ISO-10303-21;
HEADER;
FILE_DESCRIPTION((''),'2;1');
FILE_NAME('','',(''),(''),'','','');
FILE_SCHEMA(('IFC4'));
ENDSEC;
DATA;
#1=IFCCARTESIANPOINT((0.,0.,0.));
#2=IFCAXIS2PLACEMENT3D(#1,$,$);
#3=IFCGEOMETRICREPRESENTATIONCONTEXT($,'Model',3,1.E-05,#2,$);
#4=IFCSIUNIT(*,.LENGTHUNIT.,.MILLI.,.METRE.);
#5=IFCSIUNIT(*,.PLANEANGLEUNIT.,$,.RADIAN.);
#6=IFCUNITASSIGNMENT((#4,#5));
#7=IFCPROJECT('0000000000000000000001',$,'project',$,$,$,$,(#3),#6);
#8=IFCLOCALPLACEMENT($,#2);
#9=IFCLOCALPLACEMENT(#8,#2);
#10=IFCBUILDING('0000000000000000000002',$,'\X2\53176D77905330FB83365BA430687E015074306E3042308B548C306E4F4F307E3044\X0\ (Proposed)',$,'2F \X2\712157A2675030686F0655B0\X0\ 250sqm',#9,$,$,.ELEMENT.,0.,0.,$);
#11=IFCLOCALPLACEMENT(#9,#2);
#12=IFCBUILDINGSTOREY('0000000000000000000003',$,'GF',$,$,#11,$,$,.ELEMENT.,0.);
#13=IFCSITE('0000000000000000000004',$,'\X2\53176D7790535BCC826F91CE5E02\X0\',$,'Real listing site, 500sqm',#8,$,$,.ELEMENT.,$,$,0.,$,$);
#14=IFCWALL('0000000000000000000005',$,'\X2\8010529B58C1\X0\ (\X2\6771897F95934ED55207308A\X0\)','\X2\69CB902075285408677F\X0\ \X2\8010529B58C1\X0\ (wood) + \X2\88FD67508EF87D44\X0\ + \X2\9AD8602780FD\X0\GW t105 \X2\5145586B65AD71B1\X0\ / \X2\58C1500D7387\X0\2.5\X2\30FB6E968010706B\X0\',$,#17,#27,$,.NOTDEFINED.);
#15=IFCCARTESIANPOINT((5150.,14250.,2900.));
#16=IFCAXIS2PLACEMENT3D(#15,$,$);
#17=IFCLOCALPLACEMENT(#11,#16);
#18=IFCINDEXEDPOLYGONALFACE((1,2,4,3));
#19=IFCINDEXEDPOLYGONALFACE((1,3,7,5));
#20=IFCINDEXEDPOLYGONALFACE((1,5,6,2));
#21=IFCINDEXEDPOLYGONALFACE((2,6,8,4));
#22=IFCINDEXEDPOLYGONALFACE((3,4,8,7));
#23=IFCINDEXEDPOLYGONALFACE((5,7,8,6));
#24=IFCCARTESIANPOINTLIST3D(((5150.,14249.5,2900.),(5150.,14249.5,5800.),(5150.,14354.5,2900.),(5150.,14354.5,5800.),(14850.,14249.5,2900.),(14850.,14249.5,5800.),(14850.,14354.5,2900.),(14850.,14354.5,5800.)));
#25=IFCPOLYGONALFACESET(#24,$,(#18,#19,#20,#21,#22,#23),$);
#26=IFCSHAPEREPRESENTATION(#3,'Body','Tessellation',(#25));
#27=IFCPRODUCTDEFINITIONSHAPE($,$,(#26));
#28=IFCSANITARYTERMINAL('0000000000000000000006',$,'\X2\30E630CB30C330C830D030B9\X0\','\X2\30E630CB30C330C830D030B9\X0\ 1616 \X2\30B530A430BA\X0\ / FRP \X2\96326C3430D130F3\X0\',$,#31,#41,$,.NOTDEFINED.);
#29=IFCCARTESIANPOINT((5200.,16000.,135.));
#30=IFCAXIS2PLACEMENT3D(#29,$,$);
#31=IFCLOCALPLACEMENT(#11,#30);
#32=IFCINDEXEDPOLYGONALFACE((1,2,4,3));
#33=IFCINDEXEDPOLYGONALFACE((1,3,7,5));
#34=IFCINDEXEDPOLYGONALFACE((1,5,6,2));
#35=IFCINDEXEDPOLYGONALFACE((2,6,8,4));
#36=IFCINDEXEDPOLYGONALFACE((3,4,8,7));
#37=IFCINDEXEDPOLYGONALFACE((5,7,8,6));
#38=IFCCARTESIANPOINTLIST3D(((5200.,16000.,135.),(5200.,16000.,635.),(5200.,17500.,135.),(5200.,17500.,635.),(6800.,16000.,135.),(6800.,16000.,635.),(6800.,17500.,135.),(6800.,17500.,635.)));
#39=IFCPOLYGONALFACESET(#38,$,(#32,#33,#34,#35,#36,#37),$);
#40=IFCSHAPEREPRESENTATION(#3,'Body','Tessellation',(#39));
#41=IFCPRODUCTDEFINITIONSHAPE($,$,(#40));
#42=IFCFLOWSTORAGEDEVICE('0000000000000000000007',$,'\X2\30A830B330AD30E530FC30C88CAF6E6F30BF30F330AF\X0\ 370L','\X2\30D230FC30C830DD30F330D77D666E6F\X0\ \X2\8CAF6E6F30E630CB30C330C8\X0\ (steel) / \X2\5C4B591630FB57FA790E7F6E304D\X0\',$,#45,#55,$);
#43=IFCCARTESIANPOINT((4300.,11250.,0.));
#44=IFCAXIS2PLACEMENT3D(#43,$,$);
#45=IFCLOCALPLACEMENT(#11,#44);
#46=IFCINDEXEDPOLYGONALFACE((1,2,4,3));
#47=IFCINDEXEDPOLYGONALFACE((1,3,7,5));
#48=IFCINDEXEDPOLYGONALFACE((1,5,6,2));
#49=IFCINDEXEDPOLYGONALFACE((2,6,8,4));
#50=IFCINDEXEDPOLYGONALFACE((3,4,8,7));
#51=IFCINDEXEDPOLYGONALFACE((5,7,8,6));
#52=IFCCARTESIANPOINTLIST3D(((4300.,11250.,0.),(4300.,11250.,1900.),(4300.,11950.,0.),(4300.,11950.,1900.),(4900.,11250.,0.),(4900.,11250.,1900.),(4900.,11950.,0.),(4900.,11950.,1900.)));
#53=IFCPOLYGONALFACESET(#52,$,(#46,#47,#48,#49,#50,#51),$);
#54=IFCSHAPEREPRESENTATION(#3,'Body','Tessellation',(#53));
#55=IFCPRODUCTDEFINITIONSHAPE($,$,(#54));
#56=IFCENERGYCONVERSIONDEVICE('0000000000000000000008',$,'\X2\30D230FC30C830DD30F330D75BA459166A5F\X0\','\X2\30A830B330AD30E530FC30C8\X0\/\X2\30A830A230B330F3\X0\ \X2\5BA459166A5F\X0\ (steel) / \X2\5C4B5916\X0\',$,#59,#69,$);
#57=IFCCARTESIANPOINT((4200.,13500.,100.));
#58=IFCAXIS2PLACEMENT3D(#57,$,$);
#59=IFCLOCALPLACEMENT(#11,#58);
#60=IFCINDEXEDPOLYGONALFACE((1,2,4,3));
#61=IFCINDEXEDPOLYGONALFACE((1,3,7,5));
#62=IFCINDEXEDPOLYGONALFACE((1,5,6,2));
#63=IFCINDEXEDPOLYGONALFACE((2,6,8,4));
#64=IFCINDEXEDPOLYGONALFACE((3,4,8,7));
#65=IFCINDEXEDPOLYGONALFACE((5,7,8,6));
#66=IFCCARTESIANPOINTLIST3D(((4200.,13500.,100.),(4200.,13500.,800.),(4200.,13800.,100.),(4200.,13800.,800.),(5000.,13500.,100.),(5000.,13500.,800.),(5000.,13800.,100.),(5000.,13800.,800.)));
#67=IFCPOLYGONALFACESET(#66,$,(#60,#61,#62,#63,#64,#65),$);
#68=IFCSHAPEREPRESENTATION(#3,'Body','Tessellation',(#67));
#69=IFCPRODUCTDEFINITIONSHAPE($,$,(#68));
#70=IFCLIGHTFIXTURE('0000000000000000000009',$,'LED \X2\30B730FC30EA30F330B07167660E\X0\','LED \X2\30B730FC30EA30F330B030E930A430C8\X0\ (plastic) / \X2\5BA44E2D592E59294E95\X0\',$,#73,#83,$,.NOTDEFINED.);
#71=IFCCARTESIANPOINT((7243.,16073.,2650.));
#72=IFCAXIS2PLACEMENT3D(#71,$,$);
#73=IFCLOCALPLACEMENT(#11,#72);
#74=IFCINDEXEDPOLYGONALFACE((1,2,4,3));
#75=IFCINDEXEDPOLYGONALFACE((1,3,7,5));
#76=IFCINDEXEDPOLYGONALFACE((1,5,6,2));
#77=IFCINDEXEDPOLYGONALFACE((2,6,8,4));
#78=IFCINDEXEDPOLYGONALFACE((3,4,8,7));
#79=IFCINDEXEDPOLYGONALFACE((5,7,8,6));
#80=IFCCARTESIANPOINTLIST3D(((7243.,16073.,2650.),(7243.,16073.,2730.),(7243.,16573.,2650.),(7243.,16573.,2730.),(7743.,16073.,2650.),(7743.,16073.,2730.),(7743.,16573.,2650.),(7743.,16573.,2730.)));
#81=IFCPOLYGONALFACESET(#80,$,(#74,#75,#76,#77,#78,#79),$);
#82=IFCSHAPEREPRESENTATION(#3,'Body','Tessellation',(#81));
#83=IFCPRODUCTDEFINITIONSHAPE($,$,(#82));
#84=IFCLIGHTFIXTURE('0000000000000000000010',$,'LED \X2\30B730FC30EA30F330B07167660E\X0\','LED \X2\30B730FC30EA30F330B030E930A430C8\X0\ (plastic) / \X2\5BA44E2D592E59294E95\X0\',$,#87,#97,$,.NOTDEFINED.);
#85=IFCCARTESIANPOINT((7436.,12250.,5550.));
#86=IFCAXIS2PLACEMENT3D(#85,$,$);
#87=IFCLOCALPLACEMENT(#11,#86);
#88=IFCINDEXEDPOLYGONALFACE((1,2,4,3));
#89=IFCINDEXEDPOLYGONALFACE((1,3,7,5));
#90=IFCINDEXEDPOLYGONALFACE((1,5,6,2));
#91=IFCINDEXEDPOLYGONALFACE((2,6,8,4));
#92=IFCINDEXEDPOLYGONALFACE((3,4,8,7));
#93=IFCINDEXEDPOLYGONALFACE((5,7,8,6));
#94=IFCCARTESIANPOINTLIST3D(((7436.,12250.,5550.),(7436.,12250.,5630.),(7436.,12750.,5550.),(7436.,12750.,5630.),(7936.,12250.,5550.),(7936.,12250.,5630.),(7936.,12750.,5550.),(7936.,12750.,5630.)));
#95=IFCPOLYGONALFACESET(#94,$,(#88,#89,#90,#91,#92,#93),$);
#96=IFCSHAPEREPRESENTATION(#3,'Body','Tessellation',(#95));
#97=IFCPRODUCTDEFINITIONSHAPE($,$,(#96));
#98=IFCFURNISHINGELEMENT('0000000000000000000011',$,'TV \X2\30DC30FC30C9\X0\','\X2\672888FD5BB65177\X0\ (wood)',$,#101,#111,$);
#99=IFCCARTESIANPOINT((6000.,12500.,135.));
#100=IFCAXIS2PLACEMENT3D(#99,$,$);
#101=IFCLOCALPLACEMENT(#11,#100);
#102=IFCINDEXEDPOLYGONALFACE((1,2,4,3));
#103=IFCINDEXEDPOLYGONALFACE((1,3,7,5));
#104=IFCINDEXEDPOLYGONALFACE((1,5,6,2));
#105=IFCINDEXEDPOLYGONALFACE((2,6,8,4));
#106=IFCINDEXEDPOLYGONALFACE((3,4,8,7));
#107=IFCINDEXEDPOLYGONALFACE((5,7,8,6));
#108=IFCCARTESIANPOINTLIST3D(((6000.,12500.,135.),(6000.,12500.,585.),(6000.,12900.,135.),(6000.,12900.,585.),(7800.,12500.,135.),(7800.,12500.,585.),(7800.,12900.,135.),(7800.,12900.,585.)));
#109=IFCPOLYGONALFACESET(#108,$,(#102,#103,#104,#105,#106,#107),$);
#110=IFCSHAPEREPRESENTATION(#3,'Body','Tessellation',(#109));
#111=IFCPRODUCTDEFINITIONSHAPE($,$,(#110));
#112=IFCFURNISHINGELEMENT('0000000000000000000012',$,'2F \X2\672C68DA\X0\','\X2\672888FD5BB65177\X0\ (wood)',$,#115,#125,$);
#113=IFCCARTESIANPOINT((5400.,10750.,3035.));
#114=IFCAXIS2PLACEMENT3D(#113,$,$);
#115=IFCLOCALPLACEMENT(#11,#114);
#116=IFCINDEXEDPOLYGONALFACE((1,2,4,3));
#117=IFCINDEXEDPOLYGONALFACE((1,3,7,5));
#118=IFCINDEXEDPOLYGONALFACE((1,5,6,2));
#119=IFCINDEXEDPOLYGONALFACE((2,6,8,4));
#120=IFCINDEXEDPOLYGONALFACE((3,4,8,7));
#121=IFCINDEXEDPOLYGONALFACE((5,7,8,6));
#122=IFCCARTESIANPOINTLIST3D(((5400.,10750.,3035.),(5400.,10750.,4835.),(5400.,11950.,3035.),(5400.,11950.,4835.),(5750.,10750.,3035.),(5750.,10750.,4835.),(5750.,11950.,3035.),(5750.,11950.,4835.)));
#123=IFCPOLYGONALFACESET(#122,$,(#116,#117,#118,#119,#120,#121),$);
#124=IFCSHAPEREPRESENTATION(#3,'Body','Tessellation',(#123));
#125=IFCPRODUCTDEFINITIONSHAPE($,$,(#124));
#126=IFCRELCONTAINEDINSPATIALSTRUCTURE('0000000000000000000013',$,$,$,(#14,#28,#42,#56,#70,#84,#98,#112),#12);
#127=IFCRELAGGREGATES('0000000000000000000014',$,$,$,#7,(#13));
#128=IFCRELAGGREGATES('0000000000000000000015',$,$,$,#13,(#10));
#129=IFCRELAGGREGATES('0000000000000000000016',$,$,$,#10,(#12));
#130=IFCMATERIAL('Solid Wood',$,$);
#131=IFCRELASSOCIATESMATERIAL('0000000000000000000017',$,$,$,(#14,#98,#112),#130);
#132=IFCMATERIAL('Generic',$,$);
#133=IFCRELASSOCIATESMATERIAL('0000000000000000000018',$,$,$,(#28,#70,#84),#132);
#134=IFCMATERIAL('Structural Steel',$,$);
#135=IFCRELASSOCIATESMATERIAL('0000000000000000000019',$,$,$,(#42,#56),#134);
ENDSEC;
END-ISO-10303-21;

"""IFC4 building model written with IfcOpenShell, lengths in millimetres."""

from ifc_helpers import new_model, si_unit, frame, frame_2d, origin, place, context, project, spatial, rectangle, extrude, material, element, save


model = new_model("IFC4")

# Units and contexts
model_context = context("Model", 3, precision=1e-05, world=origin())
ifc_project = project(units=[si_unit("LENGTHUNIT", "METRE", prefix="MILLI"), si_unit("PLANEANGLEUNIT", "RADIAN")], contexts=[model_context])

# Site, building, storey
site_placement = place(None, origin())
site = spatial("IfcSite", under=ifc_project, at=site_placement, Name="北海道富良野市", ObjectType="Real listing site, 500sqm", CompositionType="ELEMENT", RefElevation=0.0)
building_placement = place(site_placement, origin())
building = spatial("IfcBuilding", under=site, at=building_placement, Name="北海道・茶室と縁側のある和の住まい (Proposed)", ObjectType="2F 無垢材と漆喰 250sqm", CompositionType="ELEMENT", ElevationOfRefHeight=0.0, ElevationOfTerrain=0.0)
storey_placement = place(building_placement, origin())
storey = spatial("IfcBuildingStorey", under=building, at=storey_placement, Name="GF", CompositionType="ELEMENT", Elevation=0.0)

# Shared definitions
ifc_material_1 = material(Name="Solid Wood")

# Wall
wall_1_placement = place(storey_placement, frame((5150.0, 14250.0, 2900.0)))
element("IfcWall", 1, at=wall_1_placement, inside=storey, material=ifc_material_1, Name="耐力壁 (東西間仕切り)", Description="構造用合板 耐力壁 (wood) + 製材軸組 + 高性能GW t105 充填断熱 / 壁倍率2.5・準耐火", PredefinedType="NOTDEFINED", context=model_context, shape_type="SweptSolid", body=[
    extrude(rectangle(XDim=9700.0, YDim=105.0, at=frame_2d((4850.0, 52.0))), frame((5150.0, 14250.0, 2900.0)), (0.0, 0.0, 1.0), 2900.0),
])

# Sanitary terminal
ifc_material_2 = material(Name="Generic")
sanitary_terminal_placement = place(storey_placement, frame((5200.0, 16000.0, 135.0)))
element("IfcSanitaryTerminal", 2, at=sanitary_terminal_placement, inside=storey, material=ifc_material_2, Name="ユニットバス", Description="ユニットバス 1616 サイズ / FRP 防水パン", PredefinedType="NOTDEFINED", context=model_context, shape_type="SweptSolid", body=[
    extrude(rectangle(XDim=1600.0, YDim=1500.0, at=frame_2d((800.0, 750.0))), frame((5200.0, 16000.0, 135.0)), (0.0, 0.0, 1.0), 500.0),
])

# Flow storage device
ifc_material_3 = material(Name="Structural Steel")
flow_storage_device_placement = place(storey_placement, frame((4300.0, 11250.0, 0.0)))
element("IfcFlowStorageDevice", 3, at=flow_storage_device_placement, inside=storey, material=ifc_material_3, Name="エコキュート貯湯タンク 370L", Description="ヒートポンプ給湯 貯湯ユニット (steel) / 屋外・基礎置き", context=model_context, shape_type="SweptSolid", body=[
    extrude(rectangle(XDim=600.0, YDim=700.0, at=frame_2d((300.0, 350.0))), frame((4300.0, 11250.0, 0.0)), (0.0, 0.0, 1.0), 1900.0),
])

# Energy conversion device
energy_conversion_device_placement = place(storey_placement, frame((4200.0, 13500.0, 100.0)))
element("IfcEnergyConversionDevice", 4, at=energy_conversion_device_placement, inside=storey, material=ifc_material_3, Name="ヒートポンプ室外機", Description="エコキュート/エアコン 室外機 (steel) / 屋外", context=model_context, shape_type="SweptSolid", body=[
    extrude(rectangle(XDim=800.0, YDim=300.0, at=frame_2d((400.0, 150.0))), frame((4200.0, 13500.0, 100.0)), (0.0, 0.0, 1.0), 700.0),
])

# Light fixtures
light_fixture_1_placement = place(storey_placement, frame((7243.0, 16073.0, 2650.0)))
element("IfcLightFixture", 5, at=light_fixture_1_placement, inside=storey, material=ifc_material_2, Name="LED シーリング照明", Description="LED シーリングライト (plastic) / 室中央天井", PredefinedType="NOTDEFINED", context=model_context, shape_type="SweptSolid", body=[
    extrude(rectangle(XDim=500.0, YDim=500.0, at=frame_2d((250.0, 250.0))), frame((7243.0, 16073.0, 2650.0)), (0.0, 0.0, 1.0), 80.0),
])
light_fixture_2_placement = place(storey_placement, frame((7436.0, 12250.0, 5550.0)))
element("IfcLightFixture", 6, at=light_fixture_2_placement, inside=storey, material=ifc_material_2, Name="LED シーリング照明", Description="LED シーリングライト (plastic) / 室中央天井", PredefinedType="NOTDEFINED", context=model_context, shape_type="SweptSolid", body=[
    extrude(rectangle(XDim=500.0, YDim=500.0, at=frame_2d((250.0, 250.0))), frame((7436.0, 12250.0, 5550.0)), (0.0, 0.0, 1.0), 80.0),
])

# Furnishing elements
furnishing_1_placement = place(storey_placement, frame((6000.0, 12500.0, 135.0)))
element("IfcFurnishingElement", 7, at=furnishing_1_placement, inside=storey, material=ifc_material_1, Name="TV ボード", Description="木製家具 (wood)", context=model_context, shape_type="SweptSolid", body=[
    extrude(rectangle(XDim=1800.0, YDim=400.0, at=frame_2d((900.0, 200.0))), frame((6000.0, 12500.0, 135.0)), (0.0, 0.0, 1.0), 450.0),
])
furnishing_2_placement = place(storey_placement, frame((5400.0, 10750.0, 3035.0)))
element("IfcFurnishingElement", 8, at=furnishing_2_placement, inside=storey, material=ifc_material_1, Name="2F 本棚", Description="木製家具 (wood)", context=model_context, shape_type="SweptSolid", body=[
    extrude(rectangle(XDim=350.0, YDim=1200.0, at=frame_2d((175.0, 600.0))), frame((5400.0, 10750.0, 3035.0)), (0.0, 0.0, 1.0), 1800.0),
])

save(model, "model.ifc")
